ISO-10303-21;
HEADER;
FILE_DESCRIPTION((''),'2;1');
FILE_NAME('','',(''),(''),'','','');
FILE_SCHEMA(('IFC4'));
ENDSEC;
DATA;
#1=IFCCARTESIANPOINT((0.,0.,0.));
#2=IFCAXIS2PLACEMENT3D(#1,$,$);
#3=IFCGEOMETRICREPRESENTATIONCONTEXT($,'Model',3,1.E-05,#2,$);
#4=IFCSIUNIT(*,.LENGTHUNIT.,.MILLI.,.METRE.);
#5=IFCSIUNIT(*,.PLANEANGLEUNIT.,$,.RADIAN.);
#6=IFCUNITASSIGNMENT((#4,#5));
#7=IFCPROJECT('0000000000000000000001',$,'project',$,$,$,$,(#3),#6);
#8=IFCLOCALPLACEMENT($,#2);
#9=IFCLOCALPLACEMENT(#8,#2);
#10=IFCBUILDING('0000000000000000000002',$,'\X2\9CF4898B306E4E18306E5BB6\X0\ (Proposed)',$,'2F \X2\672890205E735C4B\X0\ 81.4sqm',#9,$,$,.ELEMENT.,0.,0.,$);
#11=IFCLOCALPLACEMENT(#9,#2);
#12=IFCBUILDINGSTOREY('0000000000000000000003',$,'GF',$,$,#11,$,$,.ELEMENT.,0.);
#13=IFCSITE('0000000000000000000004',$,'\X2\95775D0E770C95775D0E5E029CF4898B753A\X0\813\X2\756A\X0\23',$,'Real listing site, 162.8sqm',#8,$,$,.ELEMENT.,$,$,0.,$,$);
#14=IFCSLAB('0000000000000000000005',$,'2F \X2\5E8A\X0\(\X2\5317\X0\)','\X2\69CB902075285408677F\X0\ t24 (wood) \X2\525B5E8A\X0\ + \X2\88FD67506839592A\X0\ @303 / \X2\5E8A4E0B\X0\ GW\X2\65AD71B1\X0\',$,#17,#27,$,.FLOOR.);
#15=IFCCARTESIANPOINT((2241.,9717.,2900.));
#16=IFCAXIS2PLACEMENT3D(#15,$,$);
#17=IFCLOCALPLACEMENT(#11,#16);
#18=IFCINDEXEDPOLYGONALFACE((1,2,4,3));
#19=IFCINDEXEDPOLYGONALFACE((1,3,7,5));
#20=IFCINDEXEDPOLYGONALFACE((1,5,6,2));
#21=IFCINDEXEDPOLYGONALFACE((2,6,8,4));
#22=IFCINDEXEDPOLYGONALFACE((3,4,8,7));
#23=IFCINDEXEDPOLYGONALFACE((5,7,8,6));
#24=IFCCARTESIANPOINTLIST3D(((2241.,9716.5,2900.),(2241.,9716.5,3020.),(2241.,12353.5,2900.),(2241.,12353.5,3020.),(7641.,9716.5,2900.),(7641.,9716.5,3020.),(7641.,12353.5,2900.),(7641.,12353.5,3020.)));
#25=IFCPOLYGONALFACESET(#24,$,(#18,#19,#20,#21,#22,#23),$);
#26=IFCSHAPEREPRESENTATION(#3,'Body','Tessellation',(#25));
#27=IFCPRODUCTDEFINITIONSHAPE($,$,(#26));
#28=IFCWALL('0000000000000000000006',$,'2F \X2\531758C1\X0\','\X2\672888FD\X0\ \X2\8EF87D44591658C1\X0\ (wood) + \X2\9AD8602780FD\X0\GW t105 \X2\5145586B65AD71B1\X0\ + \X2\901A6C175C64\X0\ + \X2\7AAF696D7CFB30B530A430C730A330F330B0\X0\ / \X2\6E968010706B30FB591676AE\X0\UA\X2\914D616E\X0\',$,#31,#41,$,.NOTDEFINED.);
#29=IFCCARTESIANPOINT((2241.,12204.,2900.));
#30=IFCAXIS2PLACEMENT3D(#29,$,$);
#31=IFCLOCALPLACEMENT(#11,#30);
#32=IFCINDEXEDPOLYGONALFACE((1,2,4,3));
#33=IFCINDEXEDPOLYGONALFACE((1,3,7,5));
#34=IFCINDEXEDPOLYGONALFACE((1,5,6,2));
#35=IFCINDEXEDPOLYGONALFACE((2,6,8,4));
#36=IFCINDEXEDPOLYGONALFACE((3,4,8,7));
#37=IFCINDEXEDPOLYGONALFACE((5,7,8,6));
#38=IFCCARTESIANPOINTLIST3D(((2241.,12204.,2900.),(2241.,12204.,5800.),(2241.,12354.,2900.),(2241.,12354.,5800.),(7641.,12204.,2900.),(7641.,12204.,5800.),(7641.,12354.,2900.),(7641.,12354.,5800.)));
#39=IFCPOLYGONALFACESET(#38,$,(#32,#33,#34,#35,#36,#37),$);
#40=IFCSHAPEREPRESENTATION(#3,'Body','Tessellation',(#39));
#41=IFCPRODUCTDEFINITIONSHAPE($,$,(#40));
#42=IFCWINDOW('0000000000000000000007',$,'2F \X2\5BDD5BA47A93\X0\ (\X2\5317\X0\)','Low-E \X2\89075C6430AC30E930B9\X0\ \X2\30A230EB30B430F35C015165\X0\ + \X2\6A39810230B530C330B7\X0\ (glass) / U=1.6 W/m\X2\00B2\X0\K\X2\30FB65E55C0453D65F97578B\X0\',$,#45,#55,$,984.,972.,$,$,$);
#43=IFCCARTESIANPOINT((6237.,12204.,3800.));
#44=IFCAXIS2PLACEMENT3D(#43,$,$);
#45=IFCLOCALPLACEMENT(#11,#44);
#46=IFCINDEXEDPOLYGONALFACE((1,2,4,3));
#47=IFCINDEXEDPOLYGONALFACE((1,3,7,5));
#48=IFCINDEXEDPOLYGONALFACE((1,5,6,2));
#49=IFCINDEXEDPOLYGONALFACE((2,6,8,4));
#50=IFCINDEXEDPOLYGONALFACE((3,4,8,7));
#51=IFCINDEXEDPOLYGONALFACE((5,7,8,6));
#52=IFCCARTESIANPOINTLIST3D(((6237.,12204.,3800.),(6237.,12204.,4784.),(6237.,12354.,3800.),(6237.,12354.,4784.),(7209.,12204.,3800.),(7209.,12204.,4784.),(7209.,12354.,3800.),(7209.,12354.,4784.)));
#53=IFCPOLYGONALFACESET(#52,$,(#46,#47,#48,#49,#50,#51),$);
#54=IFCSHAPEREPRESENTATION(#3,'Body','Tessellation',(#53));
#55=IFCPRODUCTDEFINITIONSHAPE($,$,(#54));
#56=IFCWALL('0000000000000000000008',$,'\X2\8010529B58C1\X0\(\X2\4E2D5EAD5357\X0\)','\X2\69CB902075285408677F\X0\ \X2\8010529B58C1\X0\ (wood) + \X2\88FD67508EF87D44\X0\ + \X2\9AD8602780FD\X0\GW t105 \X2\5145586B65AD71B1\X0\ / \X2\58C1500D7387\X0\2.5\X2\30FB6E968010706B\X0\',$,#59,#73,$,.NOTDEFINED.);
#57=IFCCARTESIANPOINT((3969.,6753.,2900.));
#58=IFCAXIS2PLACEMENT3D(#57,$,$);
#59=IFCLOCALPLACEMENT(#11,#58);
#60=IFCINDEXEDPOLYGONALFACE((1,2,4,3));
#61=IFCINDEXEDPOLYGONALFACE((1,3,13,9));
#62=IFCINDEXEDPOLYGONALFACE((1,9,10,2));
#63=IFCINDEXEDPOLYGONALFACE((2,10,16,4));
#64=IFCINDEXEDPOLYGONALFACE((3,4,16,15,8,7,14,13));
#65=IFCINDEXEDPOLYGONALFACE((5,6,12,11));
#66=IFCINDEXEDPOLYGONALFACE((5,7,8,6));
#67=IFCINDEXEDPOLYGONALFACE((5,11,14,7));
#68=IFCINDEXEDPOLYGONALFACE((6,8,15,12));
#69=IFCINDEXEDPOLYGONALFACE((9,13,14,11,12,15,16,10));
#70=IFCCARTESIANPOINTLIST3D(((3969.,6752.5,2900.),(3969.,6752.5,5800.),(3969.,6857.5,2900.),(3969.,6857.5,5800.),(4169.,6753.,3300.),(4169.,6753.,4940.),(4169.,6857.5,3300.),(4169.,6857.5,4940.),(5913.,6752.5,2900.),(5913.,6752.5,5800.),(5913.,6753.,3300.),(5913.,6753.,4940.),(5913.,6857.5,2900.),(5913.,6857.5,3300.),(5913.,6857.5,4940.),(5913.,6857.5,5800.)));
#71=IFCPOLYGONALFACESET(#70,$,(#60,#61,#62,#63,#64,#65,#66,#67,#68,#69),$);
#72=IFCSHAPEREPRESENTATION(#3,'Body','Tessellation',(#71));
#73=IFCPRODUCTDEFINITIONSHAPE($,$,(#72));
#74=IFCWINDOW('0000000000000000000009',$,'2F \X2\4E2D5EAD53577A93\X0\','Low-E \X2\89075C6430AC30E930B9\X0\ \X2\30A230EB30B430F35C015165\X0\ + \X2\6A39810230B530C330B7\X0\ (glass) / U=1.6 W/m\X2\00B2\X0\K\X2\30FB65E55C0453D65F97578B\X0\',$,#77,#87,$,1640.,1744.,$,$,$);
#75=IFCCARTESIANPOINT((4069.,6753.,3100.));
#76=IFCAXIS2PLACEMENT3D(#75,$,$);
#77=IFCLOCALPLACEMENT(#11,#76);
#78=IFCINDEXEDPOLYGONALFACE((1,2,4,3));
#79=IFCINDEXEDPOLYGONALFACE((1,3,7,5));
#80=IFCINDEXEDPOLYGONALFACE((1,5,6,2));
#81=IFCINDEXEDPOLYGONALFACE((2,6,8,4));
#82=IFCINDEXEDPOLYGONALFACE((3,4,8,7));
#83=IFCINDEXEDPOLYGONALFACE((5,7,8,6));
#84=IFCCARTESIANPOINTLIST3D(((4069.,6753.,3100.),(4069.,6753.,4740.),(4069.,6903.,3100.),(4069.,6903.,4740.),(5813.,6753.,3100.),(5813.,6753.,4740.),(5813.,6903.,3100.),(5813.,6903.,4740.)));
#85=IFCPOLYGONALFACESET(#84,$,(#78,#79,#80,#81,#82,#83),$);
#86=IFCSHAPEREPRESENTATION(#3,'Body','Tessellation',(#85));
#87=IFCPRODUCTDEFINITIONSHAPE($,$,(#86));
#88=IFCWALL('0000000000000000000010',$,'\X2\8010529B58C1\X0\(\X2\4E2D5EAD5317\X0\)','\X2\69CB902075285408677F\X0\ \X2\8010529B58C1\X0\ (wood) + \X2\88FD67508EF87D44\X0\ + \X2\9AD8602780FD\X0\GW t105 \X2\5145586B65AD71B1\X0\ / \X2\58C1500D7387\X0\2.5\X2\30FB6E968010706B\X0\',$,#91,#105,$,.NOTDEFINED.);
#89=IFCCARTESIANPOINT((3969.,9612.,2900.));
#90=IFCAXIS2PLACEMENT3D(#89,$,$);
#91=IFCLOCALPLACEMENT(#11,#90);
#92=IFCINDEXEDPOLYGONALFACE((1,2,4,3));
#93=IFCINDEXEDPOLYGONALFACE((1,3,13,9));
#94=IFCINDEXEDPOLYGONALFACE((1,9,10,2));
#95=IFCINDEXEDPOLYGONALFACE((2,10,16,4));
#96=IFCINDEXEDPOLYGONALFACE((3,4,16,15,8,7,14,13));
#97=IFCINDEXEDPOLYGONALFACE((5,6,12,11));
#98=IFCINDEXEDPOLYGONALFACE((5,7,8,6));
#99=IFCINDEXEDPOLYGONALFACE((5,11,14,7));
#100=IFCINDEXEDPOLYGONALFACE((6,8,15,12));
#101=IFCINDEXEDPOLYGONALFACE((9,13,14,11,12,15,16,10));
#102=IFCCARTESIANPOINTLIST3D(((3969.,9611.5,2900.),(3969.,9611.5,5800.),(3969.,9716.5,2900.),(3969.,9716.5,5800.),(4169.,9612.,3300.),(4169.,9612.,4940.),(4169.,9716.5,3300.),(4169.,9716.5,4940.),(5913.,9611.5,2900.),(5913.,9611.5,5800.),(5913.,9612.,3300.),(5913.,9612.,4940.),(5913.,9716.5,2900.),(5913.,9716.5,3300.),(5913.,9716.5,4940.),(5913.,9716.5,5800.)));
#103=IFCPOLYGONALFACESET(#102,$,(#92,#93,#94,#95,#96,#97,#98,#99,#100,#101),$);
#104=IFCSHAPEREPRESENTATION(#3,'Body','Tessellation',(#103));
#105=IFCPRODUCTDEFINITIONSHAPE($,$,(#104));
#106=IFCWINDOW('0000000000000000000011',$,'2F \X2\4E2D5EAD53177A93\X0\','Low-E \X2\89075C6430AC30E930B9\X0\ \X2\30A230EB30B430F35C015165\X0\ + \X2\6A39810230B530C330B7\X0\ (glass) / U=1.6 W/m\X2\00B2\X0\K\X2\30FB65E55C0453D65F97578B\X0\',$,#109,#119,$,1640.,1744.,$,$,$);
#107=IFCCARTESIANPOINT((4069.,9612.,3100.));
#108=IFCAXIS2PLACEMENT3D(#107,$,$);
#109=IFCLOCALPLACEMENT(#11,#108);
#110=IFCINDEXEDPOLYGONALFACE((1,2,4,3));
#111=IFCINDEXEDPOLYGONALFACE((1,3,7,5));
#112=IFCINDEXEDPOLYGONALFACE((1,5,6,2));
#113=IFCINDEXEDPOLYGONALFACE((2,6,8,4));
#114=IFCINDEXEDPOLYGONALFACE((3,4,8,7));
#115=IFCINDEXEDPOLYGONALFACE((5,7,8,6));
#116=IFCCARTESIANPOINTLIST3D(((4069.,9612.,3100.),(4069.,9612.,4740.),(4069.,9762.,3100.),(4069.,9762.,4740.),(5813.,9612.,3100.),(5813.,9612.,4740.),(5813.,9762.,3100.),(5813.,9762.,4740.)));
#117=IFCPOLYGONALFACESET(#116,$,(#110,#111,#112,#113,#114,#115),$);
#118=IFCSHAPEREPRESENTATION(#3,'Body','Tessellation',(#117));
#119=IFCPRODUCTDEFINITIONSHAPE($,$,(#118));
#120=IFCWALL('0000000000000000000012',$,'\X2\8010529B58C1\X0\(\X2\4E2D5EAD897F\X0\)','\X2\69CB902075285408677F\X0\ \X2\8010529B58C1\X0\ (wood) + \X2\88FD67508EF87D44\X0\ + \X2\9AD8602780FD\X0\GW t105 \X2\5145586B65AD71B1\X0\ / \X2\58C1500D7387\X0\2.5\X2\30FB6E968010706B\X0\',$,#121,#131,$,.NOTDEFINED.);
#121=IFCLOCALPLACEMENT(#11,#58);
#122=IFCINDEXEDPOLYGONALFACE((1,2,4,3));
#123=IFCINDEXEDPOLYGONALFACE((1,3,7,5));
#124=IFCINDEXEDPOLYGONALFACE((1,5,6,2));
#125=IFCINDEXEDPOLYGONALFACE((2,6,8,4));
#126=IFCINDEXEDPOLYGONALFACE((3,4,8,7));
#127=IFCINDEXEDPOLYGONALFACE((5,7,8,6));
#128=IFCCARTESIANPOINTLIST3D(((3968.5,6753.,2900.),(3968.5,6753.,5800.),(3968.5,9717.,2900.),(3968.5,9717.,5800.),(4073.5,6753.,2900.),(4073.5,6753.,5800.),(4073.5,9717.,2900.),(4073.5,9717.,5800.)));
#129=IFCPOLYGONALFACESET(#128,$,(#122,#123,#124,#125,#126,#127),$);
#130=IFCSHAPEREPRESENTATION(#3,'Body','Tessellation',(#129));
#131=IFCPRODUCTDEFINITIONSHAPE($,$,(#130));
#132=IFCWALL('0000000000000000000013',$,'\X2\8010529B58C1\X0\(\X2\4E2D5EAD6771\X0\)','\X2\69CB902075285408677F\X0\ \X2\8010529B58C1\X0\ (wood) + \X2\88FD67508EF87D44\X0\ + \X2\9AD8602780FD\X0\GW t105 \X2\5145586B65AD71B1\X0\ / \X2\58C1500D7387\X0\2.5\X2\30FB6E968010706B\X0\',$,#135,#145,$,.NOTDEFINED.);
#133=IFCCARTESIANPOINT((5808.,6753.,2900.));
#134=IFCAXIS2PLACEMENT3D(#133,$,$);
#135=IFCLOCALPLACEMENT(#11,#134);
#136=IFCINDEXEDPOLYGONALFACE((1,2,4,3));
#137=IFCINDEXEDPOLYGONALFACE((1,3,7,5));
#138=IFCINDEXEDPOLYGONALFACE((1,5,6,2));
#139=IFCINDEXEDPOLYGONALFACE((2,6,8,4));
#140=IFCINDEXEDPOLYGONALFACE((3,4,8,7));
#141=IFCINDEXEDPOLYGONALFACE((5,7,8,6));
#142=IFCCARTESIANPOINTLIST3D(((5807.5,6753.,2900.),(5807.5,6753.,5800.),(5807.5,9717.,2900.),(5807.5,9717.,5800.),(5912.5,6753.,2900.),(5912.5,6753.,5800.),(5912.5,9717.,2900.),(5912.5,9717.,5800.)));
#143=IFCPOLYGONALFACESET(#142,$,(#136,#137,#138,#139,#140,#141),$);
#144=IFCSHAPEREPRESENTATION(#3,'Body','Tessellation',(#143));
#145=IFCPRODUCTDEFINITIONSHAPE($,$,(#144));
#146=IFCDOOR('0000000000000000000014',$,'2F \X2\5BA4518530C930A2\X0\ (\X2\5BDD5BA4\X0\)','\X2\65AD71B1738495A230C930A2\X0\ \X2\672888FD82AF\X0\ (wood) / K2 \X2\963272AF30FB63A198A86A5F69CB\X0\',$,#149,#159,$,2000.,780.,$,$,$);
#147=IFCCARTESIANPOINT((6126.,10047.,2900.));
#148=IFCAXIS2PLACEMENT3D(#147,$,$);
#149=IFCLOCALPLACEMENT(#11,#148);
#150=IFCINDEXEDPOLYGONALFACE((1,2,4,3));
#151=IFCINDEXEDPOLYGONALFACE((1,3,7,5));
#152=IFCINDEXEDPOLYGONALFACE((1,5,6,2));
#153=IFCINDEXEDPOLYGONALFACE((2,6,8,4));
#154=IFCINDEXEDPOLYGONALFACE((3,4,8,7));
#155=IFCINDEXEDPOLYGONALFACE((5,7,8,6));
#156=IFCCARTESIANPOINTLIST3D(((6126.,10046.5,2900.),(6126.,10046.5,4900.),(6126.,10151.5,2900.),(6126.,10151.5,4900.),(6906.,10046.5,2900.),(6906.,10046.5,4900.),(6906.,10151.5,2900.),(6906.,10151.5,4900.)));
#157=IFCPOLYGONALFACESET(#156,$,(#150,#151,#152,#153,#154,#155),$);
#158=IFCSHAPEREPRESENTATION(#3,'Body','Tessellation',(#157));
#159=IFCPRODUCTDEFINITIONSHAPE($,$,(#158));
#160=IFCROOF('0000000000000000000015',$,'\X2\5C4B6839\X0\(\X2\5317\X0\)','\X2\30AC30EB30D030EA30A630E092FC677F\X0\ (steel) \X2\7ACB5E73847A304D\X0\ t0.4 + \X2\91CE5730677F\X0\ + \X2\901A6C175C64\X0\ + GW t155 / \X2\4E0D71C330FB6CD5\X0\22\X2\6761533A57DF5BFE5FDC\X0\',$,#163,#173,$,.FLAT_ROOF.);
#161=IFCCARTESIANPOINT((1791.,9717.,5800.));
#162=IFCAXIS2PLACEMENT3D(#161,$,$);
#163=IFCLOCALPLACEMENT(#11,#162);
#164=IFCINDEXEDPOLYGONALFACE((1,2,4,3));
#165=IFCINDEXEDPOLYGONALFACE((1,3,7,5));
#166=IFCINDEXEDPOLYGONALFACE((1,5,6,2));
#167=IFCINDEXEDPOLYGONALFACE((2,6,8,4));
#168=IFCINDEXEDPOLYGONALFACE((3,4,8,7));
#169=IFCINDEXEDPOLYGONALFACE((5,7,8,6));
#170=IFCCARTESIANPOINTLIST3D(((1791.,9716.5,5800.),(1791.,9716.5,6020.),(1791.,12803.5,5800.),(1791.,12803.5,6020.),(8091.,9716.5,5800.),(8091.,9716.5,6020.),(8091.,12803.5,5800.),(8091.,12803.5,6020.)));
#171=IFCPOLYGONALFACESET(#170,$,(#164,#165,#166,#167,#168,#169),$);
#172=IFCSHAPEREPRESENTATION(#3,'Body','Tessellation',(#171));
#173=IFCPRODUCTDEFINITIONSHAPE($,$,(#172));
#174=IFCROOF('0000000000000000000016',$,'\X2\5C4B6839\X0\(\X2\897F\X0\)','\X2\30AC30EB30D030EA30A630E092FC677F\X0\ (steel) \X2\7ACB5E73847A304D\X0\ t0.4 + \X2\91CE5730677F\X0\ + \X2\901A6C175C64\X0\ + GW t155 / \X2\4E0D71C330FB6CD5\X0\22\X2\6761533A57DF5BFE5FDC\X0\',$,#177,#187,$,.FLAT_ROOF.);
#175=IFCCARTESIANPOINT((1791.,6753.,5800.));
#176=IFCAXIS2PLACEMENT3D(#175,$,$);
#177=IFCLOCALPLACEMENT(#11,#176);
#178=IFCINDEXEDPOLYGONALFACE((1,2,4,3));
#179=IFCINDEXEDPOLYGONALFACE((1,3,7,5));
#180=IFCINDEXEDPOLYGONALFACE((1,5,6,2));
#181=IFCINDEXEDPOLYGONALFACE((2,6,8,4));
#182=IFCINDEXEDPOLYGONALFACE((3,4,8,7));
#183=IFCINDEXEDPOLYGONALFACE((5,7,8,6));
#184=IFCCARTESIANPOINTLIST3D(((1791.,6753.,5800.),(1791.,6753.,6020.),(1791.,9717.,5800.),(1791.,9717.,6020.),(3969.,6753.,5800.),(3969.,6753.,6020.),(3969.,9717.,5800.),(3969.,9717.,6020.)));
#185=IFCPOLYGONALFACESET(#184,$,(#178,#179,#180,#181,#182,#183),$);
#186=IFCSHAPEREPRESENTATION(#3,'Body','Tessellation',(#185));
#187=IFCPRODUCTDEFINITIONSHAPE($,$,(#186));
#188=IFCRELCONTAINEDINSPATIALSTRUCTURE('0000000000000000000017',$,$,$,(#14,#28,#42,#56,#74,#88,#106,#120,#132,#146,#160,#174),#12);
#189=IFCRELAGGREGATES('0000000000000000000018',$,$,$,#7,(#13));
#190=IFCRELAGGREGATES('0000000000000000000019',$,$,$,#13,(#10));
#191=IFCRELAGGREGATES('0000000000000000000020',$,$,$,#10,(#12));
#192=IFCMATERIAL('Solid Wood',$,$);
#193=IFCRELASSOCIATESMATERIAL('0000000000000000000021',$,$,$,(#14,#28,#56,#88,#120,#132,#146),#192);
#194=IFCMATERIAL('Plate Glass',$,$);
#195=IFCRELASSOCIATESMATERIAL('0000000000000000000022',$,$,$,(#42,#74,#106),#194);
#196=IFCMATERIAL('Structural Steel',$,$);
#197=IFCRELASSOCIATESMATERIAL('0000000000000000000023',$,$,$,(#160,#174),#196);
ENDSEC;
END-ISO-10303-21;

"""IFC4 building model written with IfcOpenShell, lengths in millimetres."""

from ifc_helpers import new_model, si_unit, frame, frame_2d, origin, place, context, project, spatial, rectangle, extrude, material, element, fill, save


model = new_model("IFC4")

# Units and contexts
model_context = context("Model", 3, precision=1e-05, world=origin())
ifc_project = project(units=[si_unit("LENGTHUNIT", "METRE", prefix="MILLI"), si_unit("PLANEANGLEUNIT", "RADIAN")], contexts=[model_context])

# Site, building, storey
site_placement = place(None, origin())
site = spatial("IfcSite", under=ifc_project, at=site_placement, Name="長崎県長崎市鳴見町813番23", ObjectType="Real listing site, 162.8sqm", CompositionType="ELEMENT", RefElevation=0.0)
building_placement = place(site_placement, origin())
building = spatial("IfcBuilding", under=site, at=building_placement, Name="鳴見の丘の家 (Proposed)", ObjectType="2F 木造平屋 81.4sqm", CompositionType="ELEMENT", ElevationOfRefHeight=0.0, ElevationOfTerrain=0.0)
storey_placement = place(building_placement, origin())
storey = spatial("IfcBuildingStorey", under=building, at=storey_placement, Name="GF", CompositionType="ELEMENT", Elevation=0.0)

# Slab
ifc_material_1 = material(Name="Solid Wood")
slab_placement = place(storey_placement, frame((2241.0, 9717.0, 2900.0)))
element("IfcSlab", 1, at=slab_placement, inside=storey, material=ifc_material_1, Name="2F 床(北)", Description="構造用合板 t24 (wood) 剛床 + 製材根太 @303 / 床下 GW断熱", PredefinedType="FLOOR", context=model_context, shape_type="SweptSolid", body=[
    extrude(rectangle(XDim=5400.0, YDim=2637.0, at=frame_2d((2700.0, 1318.0))), frame((2241.0, 9717.0, 2900.0)), (0.0, 0.0, 1.0), 120.0),
])

# Walls, openings, windows
wall_1_placement = place(storey_placement, frame((2241.0, 12204.0, 2900.0)))
wall_1 = element("IfcWall", 2, at=wall_1_placement, inside=storey, material=ifc_material_1, Name="2F 北壁", Description="木製 軸組外壁 (wood) + 高性能GW t105 充填断熱 + 通気層 + 窯業系サイディング / 準耐火・外皮UA配慮", PredefinedType="NOTDEFINED", context=model_context, shape_type="SweptSolid", body=[
    extrude(rectangle(XDim=5400.0, YDim=150.0, at=frame_2d((2700.0, 75.0))), frame((2241.0, 12204.0, 2900.0)), (0.0, 0.0, 1.0), 2900.0),
])
opening_1_placement = place(storey_placement, frame((6237.0, 12204.0, 3800.0)))
opening_1 = element("IfcOpeningElement", 3, at=opening_1_placement, cuts=wall_1, PredefinedType="NOTDEFINED", context=model_context, shape_type="SweptSolid", body=[
    extrude(rectangle(XDim=972.0, YDim=150.0, at=frame_2d((486.0, 75.0))), frame((6237.0, 12204.0, 3800.0)), (0.0, 0.0, 1.0), 984.0),
])
ifc_material_2 = material(Name="Plate Glass")
window_1_placement = place(storey_placement, frame((6237.0, 12204.0, 3800.0)))
window_1 = element("IfcWindow", 4, at=window_1_placement, inside=storey, material=ifc_material_2, Name="2F 寝室窓 (北)", Description="Low-E 複層ガラス アルゴン封入 + 樹脂サッシ (glass) / U=1.6 W/m²K・日射取得型", OverallHeight=984.0, OverallWidth=972.0, context=model_context, shape_type="SweptSolid", body=[
    extrude(rectangle(XDim=972.0, YDim=150.0, at=frame_2d((486.0, 75.0))), frame((6237.0, 12204.0, 3800.0)), (0.0, 0.0, 1.0), 984.0),
])
fill(opening_1, window_1)
wall_2_placement = place(storey_placement, frame((3969.0, 6753.0, 2900.0)))
wall_2 = element("IfcWall", 5, at=wall_2_placement, inside=storey, material=ifc_material_1, Name="耐力壁(中庭南)", Description="構造用合板 耐力壁 (wood) + 製材軸組 + 高性能GW t105 充填断熱 / 壁倍率2.5・準耐火", PredefinedType="NOTDEFINED", context=model_context, shape_type="SweptSolid", body=[
    extrude(rectangle(XDim=1944.0, YDim=105.0, at=frame_2d((972.0, 52.0))), frame((3969.0, 6753.0, 2900.0)), (0.0, 0.0, 1.0), 2900.0),
])
opening_2_placement = place(storey_placement, frame((4069.0, 6753.0, 3100.0)))
opening_2 = element("IfcOpeningElement", 6, at=opening_2_placement, cuts=wall_2, PredefinedType="NOTDEFINED", context=model_context, shape_type="SweptSolid", body=[
    extrude(rectangle(XDim=1744.0, YDim=150.0, at=frame_2d((872.0, 75.0))), frame((4069.0, 6753.0, 3100.0)), (0.0, 0.0, 1.0), 1640.0),
])
window_2_placement = place(storey_placement, frame((4069.0, 6753.0, 3100.0)))
window_2 = element("IfcWindow", 7, at=window_2_placement, inside=storey, material=ifc_material_2, Name="2F 中庭南窓", Description="Low-E 複層ガラス アルゴン封入 + 樹脂サッシ (glass) / U=1.6 W/m²K・日射取得型", OverallHeight=1640.0, OverallWidth=1744.0, context=model_context, shape_type="SweptSolid", body=[
    extrude(rectangle(XDim=1744.0, YDim=150.0, at=frame_2d((872.0, 75.0))), frame((4069.0, 6753.0, 3100.0)), (0.0, 0.0, 1.0), 1640.0),
])
fill(opening_2, window_2)
wall_3_placement = place(storey_placement, frame((3969.0, 9612.0, 2900.0)))
wall_3 = element("IfcWall", 8, at=wall_3_placement, inside=storey, material=ifc_material_1, Name="耐力壁(中庭北)", Description="構造用合板 耐力壁 (wood) + 製材軸組 + 高性能GW t105 充填断熱 / 壁倍率2.5・準耐火", PredefinedType="NOTDEFINED", context=model_context, shape_type="SweptSolid", body=[
    extrude(rectangle(XDim=1944.0, YDim=105.0, at=frame_2d((972.0, 52.0))), frame((3969.0, 9612.0, 2900.0)), (0.0, 0.0, 1.0), 2900.0),
])
opening_3_placement = place(storey_placement, frame((4069.0, 9612.0, 3100.0)))
opening_3 = element("IfcOpeningElement", 9, at=opening_3_placement, cuts=wall_3, PredefinedType="NOTDEFINED", context=model_context, shape_type="SweptSolid", body=[
    extrude(rectangle(XDim=1744.0, YDim=150.0, at=frame_2d((872.0, 75.0))), frame((4069.0, 9612.0, 3100.0)), (0.0, 0.0, 1.0), 1640.0),
])
window_3_placement = place(storey_placement, frame((4069.0, 9612.0, 3100.0)))
window_3 = element("IfcWindow", 10, at=window_3_placement, inside=storey, material=ifc_material_2, Name="2F 中庭北窓", Description="Low-E 複層ガラス アルゴン封入 + 樹脂サッシ (glass) / U=1.6 W/m²K・日射取得型", OverallHeight=1640.0, OverallWidth=1744.0, context=model_context, shape_type="SweptSolid", body=[
    extrude(rectangle(XDim=1744.0, YDim=150.0, at=frame_2d((872.0, 75.0))), frame((4069.0, 9612.0, 3100.0)), (0.0, 0.0, 1.0), 1640.0),
])
fill(opening_3, window_3)

# Walls
wall_4_placement = place(storey_placement, frame((3969.0, 6753.0, 2900.0)))
element("IfcWall", 11, at=wall_4_placement, inside=storey, material=ifc_material_1, Name="耐力壁(中庭西)", Description="構造用合板 耐力壁 (wood) + 製材軸組 + 高性能GW t105 充填断熱 / 壁倍率2.5・準耐火", PredefinedType="NOTDEFINED", context=model_context, shape_type="SweptSolid", body=[
    extrude(rectangle(XDim=105.0, YDim=2964.0, at=frame_2d((52.0, 1482.0))), frame((3969.0, 6753.0, 2900.0)), (0.0, 0.0, 1.0), 2900.0),
])
wall_5_placement = place(storey_placement, frame((5808.0, 6753.0, 2900.0)))
element("IfcWall", 12, at=wall_5_placement, inside=storey, material=ifc_material_1, Name="耐力壁(中庭東)", Description="構造用合板 耐力壁 (wood) + 製材軸組 + 高性能GW t105 充填断熱 / 壁倍率2.5・準耐火", PredefinedType="NOTDEFINED", context=model_context, shape_type="SweptSolid", body=[
    extrude(rectangle(XDim=105.0, YDim=2964.0, at=frame_2d((52.0, 1482.0))), frame((5808.0, 6753.0, 2900.0)), (0.0, 0.0, 1.0), 2900.0),
])

# Door
door_placement = place(storey_placement, frame((6126.0, 10047.0, 2900.0)))
element("IfcDoor", 13, at=door_placement, inside=storey, material=ifc_material_1, Name="2F 室内ドア (寝室)", Description="断熱玄関ドア 木製芯 (wood) / K2 防犯・採風機構", OverallHeight=2000.0, OverallWidth=780.0, context=model_context, shape_type="SweptSolid", body=[
    extrude(rectangle(XDim=780.0, YDim=105.0, at=frame_2d((390.0, 52.0))), frame((6126.0, 10047.0, 2900.0)), (0.0, 0.0, 1.0), 2000.0),
])

# Roofs
ifc_material_3 = material(Name="Structural Steel")
for number, where, name in (
    (14, (1791.0, 9717.0, 5800.0), "屋根(北)"),
):
    element("IfcRoof", number, at=place(storey_placement, frame(where)), inside=storey, material=ifc_material_3, Name=name, Description="ガルバリウム鋼板 (steel) 立平葺き t0.4 + 野地板 + 通気層 + GW t155 / 不燃・法22条区域対応", PredefinedType="FLAT_ROOF", context=model_context, shape_type="SweptSolid", body=[
        extrude(rectangle(XDim=6300.0, YDim=3087.0, at=frame_2d((3150.0, 1543.0))), frame((1791.0, 9717.0, 5800.0)), (0.0, 0.0, 1.0), 220.0),
    ])
roof_1_placement = place(storey_placement, frame((1791.0, 6753.0, 5800.0)))
element("IfcRoof", 15, at=roof_1_placement, inside=storey, material=ifc_material_3, Name="屋根(西)", Description="ガルバリウム鋼板 (steel) 立平葺き t0.4 + 野地板 + 通気層 + GW t155 / 不燃・法22条区域対応", PredefinedType="FLAT_ROOF", context=model_context, shape_type="SweptSolid", body=[
    extrude(rectangle(XDim=2178.0, YDim=2964.0, at=frame_2d((1089.0, 1482.0))), frame((1791.0, 6753.0, 5800.0)), (0.0, 0.0, 1.0), 220.0),
])

save(model, "model.ifc")
